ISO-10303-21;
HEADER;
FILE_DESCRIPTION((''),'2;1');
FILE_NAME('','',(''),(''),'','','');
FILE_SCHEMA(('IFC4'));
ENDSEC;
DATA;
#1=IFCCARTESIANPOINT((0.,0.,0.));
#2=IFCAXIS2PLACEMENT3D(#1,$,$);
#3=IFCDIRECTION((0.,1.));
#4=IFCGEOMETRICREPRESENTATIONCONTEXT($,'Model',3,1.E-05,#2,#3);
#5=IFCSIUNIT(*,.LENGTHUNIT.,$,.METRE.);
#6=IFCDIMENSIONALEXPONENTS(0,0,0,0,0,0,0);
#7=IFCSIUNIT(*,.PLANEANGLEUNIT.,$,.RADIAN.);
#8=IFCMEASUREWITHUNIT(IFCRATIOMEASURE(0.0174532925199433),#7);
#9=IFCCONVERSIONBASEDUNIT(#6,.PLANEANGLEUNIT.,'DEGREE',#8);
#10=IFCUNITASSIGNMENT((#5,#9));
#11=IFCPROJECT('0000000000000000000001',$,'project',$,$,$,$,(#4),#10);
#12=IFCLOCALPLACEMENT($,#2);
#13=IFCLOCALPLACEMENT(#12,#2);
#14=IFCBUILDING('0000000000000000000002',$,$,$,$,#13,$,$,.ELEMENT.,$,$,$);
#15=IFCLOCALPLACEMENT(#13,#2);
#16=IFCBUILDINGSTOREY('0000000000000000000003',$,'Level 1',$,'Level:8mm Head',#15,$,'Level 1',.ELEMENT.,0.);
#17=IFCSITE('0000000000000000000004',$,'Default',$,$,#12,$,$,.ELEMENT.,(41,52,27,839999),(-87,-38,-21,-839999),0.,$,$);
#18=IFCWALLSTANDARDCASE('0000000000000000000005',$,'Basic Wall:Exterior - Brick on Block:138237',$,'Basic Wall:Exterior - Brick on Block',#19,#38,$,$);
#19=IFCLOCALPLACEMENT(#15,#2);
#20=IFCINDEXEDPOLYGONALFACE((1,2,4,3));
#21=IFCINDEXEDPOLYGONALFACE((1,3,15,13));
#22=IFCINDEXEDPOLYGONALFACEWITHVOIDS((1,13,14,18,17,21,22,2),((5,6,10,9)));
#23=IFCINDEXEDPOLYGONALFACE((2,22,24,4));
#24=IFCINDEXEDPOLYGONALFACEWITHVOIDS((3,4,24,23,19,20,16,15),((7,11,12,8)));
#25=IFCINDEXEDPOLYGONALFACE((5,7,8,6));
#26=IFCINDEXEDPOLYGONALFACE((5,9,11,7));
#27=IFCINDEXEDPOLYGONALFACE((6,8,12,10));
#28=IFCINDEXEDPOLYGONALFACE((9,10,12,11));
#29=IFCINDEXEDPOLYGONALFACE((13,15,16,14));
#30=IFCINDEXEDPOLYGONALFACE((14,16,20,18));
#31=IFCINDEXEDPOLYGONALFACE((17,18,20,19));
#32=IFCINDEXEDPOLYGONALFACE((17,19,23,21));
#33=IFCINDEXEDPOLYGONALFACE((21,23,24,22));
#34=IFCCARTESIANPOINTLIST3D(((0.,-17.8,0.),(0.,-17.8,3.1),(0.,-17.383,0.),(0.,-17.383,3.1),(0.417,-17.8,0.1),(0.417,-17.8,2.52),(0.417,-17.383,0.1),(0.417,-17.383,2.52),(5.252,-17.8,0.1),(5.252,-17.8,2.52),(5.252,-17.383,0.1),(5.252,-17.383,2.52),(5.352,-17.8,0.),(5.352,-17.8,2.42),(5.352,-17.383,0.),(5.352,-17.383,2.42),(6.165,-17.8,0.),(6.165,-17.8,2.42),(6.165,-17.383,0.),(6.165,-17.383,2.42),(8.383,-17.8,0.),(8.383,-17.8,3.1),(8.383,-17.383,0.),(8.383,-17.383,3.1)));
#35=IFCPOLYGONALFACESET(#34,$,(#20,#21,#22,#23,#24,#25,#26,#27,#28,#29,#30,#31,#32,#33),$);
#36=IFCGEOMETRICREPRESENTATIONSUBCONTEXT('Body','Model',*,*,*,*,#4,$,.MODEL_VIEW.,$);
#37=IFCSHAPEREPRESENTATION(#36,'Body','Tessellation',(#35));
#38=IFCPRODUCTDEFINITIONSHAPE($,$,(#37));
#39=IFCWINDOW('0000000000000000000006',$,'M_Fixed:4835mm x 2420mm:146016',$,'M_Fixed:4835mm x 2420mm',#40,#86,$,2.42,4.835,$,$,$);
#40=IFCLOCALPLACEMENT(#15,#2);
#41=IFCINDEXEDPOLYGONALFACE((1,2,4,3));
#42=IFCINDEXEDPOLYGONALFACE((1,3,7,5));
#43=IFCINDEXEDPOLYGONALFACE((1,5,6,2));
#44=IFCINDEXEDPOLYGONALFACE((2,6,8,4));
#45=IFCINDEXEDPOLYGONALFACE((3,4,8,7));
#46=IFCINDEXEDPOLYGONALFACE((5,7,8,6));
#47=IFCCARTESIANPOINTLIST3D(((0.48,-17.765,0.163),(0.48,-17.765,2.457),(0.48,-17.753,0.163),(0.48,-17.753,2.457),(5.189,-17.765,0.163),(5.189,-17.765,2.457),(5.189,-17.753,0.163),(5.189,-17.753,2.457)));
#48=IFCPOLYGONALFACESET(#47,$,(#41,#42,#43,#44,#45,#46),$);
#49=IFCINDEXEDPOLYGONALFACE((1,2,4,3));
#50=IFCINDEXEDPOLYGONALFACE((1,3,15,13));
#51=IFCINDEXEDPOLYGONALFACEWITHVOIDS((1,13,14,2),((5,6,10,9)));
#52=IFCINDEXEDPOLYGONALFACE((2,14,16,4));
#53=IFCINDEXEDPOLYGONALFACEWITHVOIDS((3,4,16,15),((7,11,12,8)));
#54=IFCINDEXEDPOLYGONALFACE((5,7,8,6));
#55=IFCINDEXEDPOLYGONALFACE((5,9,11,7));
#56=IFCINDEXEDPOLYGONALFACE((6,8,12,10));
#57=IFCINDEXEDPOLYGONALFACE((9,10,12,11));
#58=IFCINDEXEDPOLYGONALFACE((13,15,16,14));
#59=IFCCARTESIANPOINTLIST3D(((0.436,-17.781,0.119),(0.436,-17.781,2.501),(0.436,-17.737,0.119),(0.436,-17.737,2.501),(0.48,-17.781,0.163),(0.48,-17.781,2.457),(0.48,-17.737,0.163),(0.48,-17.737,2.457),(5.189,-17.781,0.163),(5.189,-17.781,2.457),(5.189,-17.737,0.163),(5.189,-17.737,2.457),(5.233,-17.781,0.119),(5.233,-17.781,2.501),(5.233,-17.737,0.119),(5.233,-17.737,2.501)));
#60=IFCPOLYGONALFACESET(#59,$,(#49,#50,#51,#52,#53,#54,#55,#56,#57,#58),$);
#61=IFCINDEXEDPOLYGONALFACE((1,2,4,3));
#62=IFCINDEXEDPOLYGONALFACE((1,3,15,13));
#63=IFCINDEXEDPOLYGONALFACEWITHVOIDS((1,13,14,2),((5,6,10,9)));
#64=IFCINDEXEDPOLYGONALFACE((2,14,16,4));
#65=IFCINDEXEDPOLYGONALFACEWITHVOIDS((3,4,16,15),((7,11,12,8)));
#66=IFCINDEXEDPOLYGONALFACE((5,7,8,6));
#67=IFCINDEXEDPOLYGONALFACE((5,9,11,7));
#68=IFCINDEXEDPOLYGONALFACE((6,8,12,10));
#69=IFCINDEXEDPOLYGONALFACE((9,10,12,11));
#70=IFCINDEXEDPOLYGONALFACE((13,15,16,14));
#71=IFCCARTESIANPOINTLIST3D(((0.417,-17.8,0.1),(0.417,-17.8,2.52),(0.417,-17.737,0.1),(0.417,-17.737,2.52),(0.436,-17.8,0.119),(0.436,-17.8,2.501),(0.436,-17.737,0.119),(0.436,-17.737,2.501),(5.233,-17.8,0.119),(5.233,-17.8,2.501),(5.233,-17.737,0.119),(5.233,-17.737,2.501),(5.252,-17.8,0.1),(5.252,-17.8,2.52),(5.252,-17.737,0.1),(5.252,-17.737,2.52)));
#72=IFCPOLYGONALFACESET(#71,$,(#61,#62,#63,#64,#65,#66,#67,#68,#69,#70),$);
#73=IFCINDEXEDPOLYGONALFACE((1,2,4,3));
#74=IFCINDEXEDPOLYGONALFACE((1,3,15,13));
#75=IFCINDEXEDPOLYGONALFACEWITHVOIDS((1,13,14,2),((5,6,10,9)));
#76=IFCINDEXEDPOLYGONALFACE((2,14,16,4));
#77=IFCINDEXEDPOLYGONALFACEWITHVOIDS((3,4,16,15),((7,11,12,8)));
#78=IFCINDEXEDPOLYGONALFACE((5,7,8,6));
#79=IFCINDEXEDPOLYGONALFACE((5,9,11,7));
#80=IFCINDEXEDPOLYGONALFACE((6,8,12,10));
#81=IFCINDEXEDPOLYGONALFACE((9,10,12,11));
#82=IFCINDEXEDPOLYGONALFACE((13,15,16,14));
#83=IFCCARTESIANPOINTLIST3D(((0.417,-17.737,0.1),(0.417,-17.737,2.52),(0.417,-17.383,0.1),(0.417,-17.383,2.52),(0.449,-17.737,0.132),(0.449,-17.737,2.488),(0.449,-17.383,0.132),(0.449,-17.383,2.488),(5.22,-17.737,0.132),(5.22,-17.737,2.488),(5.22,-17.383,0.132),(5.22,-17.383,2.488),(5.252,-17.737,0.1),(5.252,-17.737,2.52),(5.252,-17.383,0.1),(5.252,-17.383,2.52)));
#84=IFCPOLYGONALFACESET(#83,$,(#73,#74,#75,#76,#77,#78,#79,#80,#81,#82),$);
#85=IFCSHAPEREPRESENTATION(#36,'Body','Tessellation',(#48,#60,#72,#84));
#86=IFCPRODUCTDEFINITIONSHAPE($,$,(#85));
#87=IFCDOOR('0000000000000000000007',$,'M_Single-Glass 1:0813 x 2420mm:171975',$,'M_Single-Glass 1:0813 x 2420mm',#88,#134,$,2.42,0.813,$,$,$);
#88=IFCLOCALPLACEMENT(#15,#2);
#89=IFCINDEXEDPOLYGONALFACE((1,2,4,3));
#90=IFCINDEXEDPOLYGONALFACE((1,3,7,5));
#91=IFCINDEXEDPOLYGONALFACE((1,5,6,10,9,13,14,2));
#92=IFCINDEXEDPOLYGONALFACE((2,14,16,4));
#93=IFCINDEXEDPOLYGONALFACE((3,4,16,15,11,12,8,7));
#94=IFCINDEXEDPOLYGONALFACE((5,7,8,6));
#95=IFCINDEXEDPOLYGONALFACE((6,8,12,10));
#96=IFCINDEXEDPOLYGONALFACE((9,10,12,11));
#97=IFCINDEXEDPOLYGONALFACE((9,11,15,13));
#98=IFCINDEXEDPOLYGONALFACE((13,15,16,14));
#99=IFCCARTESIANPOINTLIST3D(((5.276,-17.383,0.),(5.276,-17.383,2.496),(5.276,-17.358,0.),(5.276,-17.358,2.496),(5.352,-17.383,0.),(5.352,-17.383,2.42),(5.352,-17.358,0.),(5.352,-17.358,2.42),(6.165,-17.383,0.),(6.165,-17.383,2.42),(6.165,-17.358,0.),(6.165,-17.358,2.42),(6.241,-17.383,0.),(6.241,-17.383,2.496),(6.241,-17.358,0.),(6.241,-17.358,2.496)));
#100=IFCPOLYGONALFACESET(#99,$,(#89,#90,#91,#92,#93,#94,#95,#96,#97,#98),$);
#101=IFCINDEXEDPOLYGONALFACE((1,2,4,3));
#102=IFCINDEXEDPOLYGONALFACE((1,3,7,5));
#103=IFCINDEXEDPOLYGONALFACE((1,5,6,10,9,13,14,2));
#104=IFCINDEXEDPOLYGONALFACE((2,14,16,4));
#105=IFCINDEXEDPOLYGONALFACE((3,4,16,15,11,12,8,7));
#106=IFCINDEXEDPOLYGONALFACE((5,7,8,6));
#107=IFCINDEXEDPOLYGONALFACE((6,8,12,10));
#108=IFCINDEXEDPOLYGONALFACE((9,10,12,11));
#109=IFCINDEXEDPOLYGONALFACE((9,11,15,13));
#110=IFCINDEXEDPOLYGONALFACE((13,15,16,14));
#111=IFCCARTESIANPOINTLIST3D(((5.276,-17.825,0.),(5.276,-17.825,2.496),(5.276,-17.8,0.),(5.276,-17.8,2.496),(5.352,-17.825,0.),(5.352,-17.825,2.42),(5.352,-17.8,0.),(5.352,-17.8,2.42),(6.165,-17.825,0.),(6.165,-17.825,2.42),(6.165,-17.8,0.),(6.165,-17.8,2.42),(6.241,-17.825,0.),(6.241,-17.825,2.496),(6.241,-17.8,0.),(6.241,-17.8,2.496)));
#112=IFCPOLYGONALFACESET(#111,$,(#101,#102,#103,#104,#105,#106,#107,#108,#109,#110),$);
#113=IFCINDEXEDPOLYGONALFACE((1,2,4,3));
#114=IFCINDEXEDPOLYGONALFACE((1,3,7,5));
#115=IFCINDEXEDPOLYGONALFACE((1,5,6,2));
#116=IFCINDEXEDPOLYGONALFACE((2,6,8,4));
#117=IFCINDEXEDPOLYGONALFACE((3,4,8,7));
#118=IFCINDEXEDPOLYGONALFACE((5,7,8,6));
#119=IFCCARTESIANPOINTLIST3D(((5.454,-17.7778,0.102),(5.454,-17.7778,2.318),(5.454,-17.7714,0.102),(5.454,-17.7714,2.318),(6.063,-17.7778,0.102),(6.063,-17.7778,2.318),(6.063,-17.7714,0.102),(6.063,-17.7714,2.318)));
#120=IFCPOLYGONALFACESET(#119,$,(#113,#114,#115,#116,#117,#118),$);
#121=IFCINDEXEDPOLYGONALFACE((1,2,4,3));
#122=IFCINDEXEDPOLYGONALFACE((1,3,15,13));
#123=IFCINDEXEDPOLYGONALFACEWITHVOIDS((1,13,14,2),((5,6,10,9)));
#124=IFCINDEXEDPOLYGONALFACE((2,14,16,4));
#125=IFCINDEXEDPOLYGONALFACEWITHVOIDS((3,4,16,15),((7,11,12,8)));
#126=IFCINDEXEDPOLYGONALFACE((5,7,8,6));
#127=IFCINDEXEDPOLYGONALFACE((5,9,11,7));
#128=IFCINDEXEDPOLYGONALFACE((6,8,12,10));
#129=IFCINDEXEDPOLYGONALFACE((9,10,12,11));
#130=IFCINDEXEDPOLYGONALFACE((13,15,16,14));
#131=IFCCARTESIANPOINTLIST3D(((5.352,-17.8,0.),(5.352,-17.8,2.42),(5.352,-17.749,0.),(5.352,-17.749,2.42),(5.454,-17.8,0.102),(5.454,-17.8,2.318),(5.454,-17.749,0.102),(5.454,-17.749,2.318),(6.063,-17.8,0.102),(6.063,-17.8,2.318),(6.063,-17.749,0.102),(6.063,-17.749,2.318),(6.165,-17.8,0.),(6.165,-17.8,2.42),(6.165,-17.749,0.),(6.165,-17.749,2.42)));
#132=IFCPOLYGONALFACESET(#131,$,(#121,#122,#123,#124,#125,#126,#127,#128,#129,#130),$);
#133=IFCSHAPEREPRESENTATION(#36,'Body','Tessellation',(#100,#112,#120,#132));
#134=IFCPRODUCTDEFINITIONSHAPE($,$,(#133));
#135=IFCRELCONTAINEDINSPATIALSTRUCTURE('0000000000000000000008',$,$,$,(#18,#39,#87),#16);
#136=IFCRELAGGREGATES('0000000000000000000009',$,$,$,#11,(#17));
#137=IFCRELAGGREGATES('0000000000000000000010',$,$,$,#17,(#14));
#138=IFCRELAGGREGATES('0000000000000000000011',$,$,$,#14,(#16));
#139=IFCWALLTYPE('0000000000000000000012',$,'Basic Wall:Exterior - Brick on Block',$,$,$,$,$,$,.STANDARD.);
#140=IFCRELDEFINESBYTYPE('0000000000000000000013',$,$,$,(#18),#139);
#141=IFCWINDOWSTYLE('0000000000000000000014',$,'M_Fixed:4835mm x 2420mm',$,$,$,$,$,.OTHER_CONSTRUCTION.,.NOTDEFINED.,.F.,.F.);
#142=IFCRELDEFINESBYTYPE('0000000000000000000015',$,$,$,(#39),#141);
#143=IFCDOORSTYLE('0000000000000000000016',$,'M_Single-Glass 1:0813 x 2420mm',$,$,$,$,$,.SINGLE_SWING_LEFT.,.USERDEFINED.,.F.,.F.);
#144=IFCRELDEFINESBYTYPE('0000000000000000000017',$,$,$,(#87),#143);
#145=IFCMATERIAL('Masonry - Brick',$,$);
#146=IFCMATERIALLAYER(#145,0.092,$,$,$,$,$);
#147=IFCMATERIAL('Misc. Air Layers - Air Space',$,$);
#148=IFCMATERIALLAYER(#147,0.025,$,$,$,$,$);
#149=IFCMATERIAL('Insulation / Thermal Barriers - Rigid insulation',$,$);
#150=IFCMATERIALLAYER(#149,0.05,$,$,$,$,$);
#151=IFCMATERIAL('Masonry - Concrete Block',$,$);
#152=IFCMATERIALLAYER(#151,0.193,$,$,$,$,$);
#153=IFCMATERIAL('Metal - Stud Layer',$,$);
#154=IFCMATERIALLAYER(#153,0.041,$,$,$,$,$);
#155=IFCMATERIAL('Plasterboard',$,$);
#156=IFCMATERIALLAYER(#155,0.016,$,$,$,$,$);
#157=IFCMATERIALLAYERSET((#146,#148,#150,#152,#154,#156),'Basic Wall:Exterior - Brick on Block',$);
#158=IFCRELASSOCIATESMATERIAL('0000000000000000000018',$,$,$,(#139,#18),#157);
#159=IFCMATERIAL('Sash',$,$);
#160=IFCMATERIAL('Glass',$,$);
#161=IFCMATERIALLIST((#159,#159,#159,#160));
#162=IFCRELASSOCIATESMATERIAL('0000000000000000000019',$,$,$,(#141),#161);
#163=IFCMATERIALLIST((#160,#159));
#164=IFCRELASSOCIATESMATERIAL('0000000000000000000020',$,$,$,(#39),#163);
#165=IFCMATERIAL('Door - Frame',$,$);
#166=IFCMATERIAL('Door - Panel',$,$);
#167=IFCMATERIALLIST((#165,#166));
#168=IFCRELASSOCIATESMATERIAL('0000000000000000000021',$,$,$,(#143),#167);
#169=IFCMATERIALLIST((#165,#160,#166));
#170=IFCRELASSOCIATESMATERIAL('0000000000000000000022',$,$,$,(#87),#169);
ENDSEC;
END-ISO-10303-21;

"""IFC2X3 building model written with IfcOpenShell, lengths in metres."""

from ifc_helpers import new_model, entity, si_unit, converted_unit, direction, frame, frame_2d, origin, origin_2d_with_axis, place, context, subcontext, project, spatial, polyline, rectangle, outline, extrude, source, transform, mapped, material, material_list, layer, layer_set, layer_usage, type_object, type_shapes, element, fill, save


model = new_model("IFC2X3")

# Units and contexts
model_context = context("Model", 3, precision=1e-05, world=origin(), true_north=direction((0.0, 1.0)))
body_context = subcontext(model_context, "Body", "Model", "MODEL_VIEW")
ifc_project = project(units=[si_unit("LENGTHUNIT", "METRE"), converted_unit("PLANEANGLEUNIT", "DEGREE", entity("IfcRatioMeasure", 0.0174532925199433), si_unit("PLANEANGLEUNIT", "RADIAN"), dimensions=[0, 0, 0, 0, 0, 0, 0])], contexts=[model_context])

# Site, building, storey
site_placement = place(None, origin())
site = spatial("IfcSite", under=ifc_project, at=site_placement, Name="Default", CompositionType="ELEMENT", RefLatitude=(41, 52, 27, 839999), RefLongitude=(-87, -38, -21, -839999), RefElevation=0.0)
building_placement = place(site_placement, origin())
building = spatial("IfcBuilding", under=site, at=building_placement, CompositionType="ELEMENT")
storey_placement = place(building_placement, origin())
storey = spatial("IfcBuildingStorey", under=building, at=storey_placement, Name="Level 1", ObjectType="Level:8mm Head", LongName="Level 1", CompositionType="ELEMENT", Elevation=0.0)

# Wall, openings, window, door
ifc_material_1 = material(Name="Masonry - Brick")
ifc_layer_1 = layer(ifc_material_1, 0.092)
ifc_material_2 = material(Name="Misc. Air Layers - Air Space")
ifc_layer_2 = layer(ifc_material_2, 0.025)
ifc_material_3 = material(Name="Insulation / Thermal Barriers - Rigid insulation")
ifc_layer_3 = layer(ifc_material_3, 0.05)
ifc_material_4 = material(Name="Masonry - Concrete Block")
ifc_layer_4 = layer(ifc_material_4, 0.193)
ifc_material_5 = material(Name="Metal - Stud Layer")
ifc_layer_5 = layer(ifc_material_5, 0.041)
ifc_material_6 = material(Name="Plasterboard")
ifc_layer_6 = layer(ifc_material_6, 0.016)
ifc_layer_set_1 = layer_set([ifc_layer_1, ifc_layer_2, ifc_layer_3, ifc_layer_4, ifc_layer_5, ifc_layer_6], Name="Basic Wall:Exterior - Brick on Block")
ifc_layer_usage_1 = layer_usage(ifc_layer_set_1, "AXIS2", "NEGATIVE", 0.2085)
wall_type_1 = type_object("IfcWallType", Name="Basic Wall:Exterior - Brick on Block", PredefinedType="STANDARD", material=ifc_layer_set_1)
wall_1_placement = place(storey_placement, frame((8.383, -17.5915, 0.0), z_axis=(0.0, 0.0, 1.0), x_axis=(-1.0, 0.0, 0.0)))
wall_1 = element("IfcWallStandardCase", 1, at=wall_1_placement, inside=storey, type_object=wall_type_1, material=ifc_layer_usage_1, Name="Basic Wall:Exterior - Brick on Block:138237", ObjectType="Basic Wall:Exterior - Brick on Block", context=body_context, shape_type="SweptSolid", body=[
    extrude(rectangle(XDim=8.383, YDim=0.417, at=frame_2d((4.1915, 0.0), x_axis=(-1.0, 0.0))), origin(), (0.0, 0.0, 1.0), 3.1),
])
opening_1_placement = place(wall_1_placement, frame((2.218, -0.2085, 0.0)))
opening_1 = element("IfcOpeningElement", 2, at=opening_1_placement, cuts=wall_1, ObjectType="Opening", context=body_context, shape_type="SweptSolid", body=[
    extrude(rectangle(XDim=0.813, YDim=2.42, at=frame_2d((1.21, 0.4065), x_axis=(0.0, -1.0))), frame((0.0, 0.0, 0.0), z_axis=(0.0, 1.0, 0.0), x_axis=(0.0, 0.0, 1.0)), (0.0, 0.0, 1.0), 0.417),
])
opening_2_placement = place(wall_1_placement, frame((3.131, -0.2085, 0.1)))
opening_2 = element("IfcOpeningElement", 3, at=opening_2_placement, cuts=wall_1, ObjectType="Opening", context=body_context, shape_type="SweptSolid", body=[
    extrude(rectangle(XDim=2.42, YDim=4.835, at=frame_2d((1.21, 2.4175), x_axis=(1.0, 0.0))), frame((0.0, 0.0, 0.0), z_axis=(0.0, 1.0, 0.0), x_axis=(0.0, 0.0, 1.0)), (0.0, 0.0, 1.0), 0.417),
])
ifc_material_7 = material(Name="Glass")
ifc_material_8 = material(Name="Sash")
ifc_material_list_1 = material_list([ifc_material_7, ifc_material_8])
ifc_material_list_2 = material_list([ifc_material_8, ifc_material_8, ifc_material_8, ifc_material_7])
window_style_1 = type_object("IfcWindowStyle", Name="M_Fixed:4835mm x 2420mm", ConstructionType="OTHER_CONSTRUCTION", OperationType="NOTDEFINED", ParameterTakesPrecedence=False, Sizeable=False, material=ifc_material_list_2)
shared_shape_1 = source(origin(), body_context, "Body", "SweptSolid", [
    extrude(rectangle(XDim=0.012, YDim=4.709, at=origin_2d_with_axis()), frame((2.4175, 0.376, 0.063), z_axis=(0.0, 0.0, 1.0), x_axis=(0.0, -1.0, 0.0)), (0.0, 0.0, 1.0), 2.294),
    extrude(outline(polyline([(-2.3985, -1.191), (2.3985, -1.191), (2.3985, 1.191), (-2.3985, 1.191), (-2.3985, -1.191)]), holes=[polyline([(-2.3545, -1.147), (-2.3545, 1.147), (2.3545, 1.147), (2.3545, -1.147), (-2.3545, -1.147)])]), frame((2.4175, 0.354, 1.21), z_axis=(0.0, 1.0, 0.0), x_axis=(1.0, 0.0, 0.0)), (0.0, 0.0, 1.0), 0.044),
    extrude(outline(polyline([(-2.4175, -1.21), (2.4175, -1.21), (2.4175, 1.21), (-2.4175, 1.21), (-2.4175, -1.21)]), holes=[polyline([(-2.3985, -1.191), (-2.3985, 1.191), (2.3985, 1.191), (2.3985, -1.191), (-2.3985, -1.191)])]), frame((2.4175, 0.354, 1.21), z_axis=(0.0, 1.0, 0.0), x_axis=(1.0, 0.0, 0.0)), (0.0, 0.0, 1.0), 0.063),
    extrude(outline(polyline([(-2.4175, -1.21), (2.4175, -1.21), (2.4175, 1.21), (-2.4175, 1.21), (-2.4175, -1.21)]), holes=[polyline([(-2.3855, -1.178), (-2.3855, 1.178), (2.3855, 1.178), (2.3855, -1.178), (-2.3855, -1.178)])]), frame((2.4175, 0.0, 1.21), z_axis=(0.0, 1.0, 0.0), x_axis=(1.0, 0.0, 0.0)), (0.0, 0.0, 1.0), 0.354),
])
type_shapes(window_style_1, [shared_shape_1])
window_1_placement = place(opening_2_placement, origin())
window_1 = element("IfcWindow", 4, at=window_1_placement, inside=storey, type_object=window_style_1, material=ifc_material_list_1, Name="M_Fixed:4835mm x 2420mm:146016", ObjectType="M_Fixed:4835mm x 2420mm", OverallHeight=2.42, OverallWidth=4.835, context=body_context, shape_type="MappedRepresentation", body=[
    mapped(shared_shape_1, transform((0.0, 0.0, 0.0), scale=1.0)),
])
fill(opening_2, window_1)
ifc_material_9 = material(Name="Door - Frame")
ifc_material_10 = material(Name="Door - Panel")
ifc_material_list_3 = material_list([ifc_material_9, ifc_material_7, ifc_material_10])
ifc_material_list_4 = material_list([ifc_material_9, ifc_material_10])
door_style_1 = type_object("IfcDoorStyle", Name="M_Single-Glass 1:0813 x 2420mm", ConstructionType="USERDEFINED", OperationType="SINGLE_SWING_LEFT", ParameterTakesPrecedence=False, Sizeable=False, material=ifc_material_list_4)
shared_shape_2 = source(origin(), body_context, "Body", "SweptSolid", [
    extrude(outline(polyline([(-0.4065, -1.191), (-0.4065, 1.229), (-0.4825, 1.229), (-0.4825, -1.267), (0.4825, -1.267), (0.4825, 1.229), (0.4065, 1.229), (0.4065, -1.191), (-0.4065, -1.191)])), frame((0.4065, 0.0, 1.229), z_axis=(0.0, 1.0, 0.0), x_axis=(1.0, 0.0, 0.0)), (0.0, 0.0, -1.0), 0.025),
    extrude(outline(polyline([(-0.4065, -1.191), (-0.4065, 1.229), (-0.4825, 1.229), (-0.4825, -1.267), (0.4825, -1.267), (0.4825, 1.229), (0.4065, 1.229), (0.4065, -1.191), (-0.4065, -1.191)])), frame((0.4065, 0.442, 1.229), z_axis=(0.0, 1.0, 0.0), x_axis=(1.0, 0.0, 0.0)), (0.0, 0.0, -1.0), 0.025),
    extrude(rectangle(XDim=0.609, YDim=0.0064, at=frame_2d((0.0, 0.0), x_axis=(1.0, 0.0))), frame((0.4065, 0.3916, 0.102)), (0.0, 0.0, 1.0), 2.216),
    extrude(outline(polyline([(-1.21, -0.4065), (1.21, -0.4065), (1.21, 0.4065), (-1.21, 0.4065), (-1.21, -0.4065)]), holes=[polyline([(-1.108, 0.3045), (1.108, 0.3045), (1.108, -0.3045), (-1.108, -0.3045), (-1.108, 0.3045)])]), frame((0.4065, 0.417, 1.21), z_axis=(0.0, -1.0, 0.0), x_axis=(0.0, 0.0, -1.0)), (0.0, 0.0, 1.0), 0.051),
])
type_shapes(door_style_1, [shared_shape_2])
door_1_placement = place(opening_1_placement, origin())
door_1 = element("IfcDoor", 5, at=door_1_placement, inside=storey, type_object=door_style_1, material=ifc_material_list_3, Name="M_Single-Glass 1:0813 x 2420mm:171975", ObjectType="M_Single-Glass 1:0813 x 2420mm", OverallHeight=2.42, OverallWidth=0.813, context=body_context, shape_type="MappedRepresentation", body=[
    mapped(shared_shape_2, transform((0.0, 0.0, 0.0), scale=1.0)),
])
fill(opening_1, door_1)

save(model, "model.ifc")
